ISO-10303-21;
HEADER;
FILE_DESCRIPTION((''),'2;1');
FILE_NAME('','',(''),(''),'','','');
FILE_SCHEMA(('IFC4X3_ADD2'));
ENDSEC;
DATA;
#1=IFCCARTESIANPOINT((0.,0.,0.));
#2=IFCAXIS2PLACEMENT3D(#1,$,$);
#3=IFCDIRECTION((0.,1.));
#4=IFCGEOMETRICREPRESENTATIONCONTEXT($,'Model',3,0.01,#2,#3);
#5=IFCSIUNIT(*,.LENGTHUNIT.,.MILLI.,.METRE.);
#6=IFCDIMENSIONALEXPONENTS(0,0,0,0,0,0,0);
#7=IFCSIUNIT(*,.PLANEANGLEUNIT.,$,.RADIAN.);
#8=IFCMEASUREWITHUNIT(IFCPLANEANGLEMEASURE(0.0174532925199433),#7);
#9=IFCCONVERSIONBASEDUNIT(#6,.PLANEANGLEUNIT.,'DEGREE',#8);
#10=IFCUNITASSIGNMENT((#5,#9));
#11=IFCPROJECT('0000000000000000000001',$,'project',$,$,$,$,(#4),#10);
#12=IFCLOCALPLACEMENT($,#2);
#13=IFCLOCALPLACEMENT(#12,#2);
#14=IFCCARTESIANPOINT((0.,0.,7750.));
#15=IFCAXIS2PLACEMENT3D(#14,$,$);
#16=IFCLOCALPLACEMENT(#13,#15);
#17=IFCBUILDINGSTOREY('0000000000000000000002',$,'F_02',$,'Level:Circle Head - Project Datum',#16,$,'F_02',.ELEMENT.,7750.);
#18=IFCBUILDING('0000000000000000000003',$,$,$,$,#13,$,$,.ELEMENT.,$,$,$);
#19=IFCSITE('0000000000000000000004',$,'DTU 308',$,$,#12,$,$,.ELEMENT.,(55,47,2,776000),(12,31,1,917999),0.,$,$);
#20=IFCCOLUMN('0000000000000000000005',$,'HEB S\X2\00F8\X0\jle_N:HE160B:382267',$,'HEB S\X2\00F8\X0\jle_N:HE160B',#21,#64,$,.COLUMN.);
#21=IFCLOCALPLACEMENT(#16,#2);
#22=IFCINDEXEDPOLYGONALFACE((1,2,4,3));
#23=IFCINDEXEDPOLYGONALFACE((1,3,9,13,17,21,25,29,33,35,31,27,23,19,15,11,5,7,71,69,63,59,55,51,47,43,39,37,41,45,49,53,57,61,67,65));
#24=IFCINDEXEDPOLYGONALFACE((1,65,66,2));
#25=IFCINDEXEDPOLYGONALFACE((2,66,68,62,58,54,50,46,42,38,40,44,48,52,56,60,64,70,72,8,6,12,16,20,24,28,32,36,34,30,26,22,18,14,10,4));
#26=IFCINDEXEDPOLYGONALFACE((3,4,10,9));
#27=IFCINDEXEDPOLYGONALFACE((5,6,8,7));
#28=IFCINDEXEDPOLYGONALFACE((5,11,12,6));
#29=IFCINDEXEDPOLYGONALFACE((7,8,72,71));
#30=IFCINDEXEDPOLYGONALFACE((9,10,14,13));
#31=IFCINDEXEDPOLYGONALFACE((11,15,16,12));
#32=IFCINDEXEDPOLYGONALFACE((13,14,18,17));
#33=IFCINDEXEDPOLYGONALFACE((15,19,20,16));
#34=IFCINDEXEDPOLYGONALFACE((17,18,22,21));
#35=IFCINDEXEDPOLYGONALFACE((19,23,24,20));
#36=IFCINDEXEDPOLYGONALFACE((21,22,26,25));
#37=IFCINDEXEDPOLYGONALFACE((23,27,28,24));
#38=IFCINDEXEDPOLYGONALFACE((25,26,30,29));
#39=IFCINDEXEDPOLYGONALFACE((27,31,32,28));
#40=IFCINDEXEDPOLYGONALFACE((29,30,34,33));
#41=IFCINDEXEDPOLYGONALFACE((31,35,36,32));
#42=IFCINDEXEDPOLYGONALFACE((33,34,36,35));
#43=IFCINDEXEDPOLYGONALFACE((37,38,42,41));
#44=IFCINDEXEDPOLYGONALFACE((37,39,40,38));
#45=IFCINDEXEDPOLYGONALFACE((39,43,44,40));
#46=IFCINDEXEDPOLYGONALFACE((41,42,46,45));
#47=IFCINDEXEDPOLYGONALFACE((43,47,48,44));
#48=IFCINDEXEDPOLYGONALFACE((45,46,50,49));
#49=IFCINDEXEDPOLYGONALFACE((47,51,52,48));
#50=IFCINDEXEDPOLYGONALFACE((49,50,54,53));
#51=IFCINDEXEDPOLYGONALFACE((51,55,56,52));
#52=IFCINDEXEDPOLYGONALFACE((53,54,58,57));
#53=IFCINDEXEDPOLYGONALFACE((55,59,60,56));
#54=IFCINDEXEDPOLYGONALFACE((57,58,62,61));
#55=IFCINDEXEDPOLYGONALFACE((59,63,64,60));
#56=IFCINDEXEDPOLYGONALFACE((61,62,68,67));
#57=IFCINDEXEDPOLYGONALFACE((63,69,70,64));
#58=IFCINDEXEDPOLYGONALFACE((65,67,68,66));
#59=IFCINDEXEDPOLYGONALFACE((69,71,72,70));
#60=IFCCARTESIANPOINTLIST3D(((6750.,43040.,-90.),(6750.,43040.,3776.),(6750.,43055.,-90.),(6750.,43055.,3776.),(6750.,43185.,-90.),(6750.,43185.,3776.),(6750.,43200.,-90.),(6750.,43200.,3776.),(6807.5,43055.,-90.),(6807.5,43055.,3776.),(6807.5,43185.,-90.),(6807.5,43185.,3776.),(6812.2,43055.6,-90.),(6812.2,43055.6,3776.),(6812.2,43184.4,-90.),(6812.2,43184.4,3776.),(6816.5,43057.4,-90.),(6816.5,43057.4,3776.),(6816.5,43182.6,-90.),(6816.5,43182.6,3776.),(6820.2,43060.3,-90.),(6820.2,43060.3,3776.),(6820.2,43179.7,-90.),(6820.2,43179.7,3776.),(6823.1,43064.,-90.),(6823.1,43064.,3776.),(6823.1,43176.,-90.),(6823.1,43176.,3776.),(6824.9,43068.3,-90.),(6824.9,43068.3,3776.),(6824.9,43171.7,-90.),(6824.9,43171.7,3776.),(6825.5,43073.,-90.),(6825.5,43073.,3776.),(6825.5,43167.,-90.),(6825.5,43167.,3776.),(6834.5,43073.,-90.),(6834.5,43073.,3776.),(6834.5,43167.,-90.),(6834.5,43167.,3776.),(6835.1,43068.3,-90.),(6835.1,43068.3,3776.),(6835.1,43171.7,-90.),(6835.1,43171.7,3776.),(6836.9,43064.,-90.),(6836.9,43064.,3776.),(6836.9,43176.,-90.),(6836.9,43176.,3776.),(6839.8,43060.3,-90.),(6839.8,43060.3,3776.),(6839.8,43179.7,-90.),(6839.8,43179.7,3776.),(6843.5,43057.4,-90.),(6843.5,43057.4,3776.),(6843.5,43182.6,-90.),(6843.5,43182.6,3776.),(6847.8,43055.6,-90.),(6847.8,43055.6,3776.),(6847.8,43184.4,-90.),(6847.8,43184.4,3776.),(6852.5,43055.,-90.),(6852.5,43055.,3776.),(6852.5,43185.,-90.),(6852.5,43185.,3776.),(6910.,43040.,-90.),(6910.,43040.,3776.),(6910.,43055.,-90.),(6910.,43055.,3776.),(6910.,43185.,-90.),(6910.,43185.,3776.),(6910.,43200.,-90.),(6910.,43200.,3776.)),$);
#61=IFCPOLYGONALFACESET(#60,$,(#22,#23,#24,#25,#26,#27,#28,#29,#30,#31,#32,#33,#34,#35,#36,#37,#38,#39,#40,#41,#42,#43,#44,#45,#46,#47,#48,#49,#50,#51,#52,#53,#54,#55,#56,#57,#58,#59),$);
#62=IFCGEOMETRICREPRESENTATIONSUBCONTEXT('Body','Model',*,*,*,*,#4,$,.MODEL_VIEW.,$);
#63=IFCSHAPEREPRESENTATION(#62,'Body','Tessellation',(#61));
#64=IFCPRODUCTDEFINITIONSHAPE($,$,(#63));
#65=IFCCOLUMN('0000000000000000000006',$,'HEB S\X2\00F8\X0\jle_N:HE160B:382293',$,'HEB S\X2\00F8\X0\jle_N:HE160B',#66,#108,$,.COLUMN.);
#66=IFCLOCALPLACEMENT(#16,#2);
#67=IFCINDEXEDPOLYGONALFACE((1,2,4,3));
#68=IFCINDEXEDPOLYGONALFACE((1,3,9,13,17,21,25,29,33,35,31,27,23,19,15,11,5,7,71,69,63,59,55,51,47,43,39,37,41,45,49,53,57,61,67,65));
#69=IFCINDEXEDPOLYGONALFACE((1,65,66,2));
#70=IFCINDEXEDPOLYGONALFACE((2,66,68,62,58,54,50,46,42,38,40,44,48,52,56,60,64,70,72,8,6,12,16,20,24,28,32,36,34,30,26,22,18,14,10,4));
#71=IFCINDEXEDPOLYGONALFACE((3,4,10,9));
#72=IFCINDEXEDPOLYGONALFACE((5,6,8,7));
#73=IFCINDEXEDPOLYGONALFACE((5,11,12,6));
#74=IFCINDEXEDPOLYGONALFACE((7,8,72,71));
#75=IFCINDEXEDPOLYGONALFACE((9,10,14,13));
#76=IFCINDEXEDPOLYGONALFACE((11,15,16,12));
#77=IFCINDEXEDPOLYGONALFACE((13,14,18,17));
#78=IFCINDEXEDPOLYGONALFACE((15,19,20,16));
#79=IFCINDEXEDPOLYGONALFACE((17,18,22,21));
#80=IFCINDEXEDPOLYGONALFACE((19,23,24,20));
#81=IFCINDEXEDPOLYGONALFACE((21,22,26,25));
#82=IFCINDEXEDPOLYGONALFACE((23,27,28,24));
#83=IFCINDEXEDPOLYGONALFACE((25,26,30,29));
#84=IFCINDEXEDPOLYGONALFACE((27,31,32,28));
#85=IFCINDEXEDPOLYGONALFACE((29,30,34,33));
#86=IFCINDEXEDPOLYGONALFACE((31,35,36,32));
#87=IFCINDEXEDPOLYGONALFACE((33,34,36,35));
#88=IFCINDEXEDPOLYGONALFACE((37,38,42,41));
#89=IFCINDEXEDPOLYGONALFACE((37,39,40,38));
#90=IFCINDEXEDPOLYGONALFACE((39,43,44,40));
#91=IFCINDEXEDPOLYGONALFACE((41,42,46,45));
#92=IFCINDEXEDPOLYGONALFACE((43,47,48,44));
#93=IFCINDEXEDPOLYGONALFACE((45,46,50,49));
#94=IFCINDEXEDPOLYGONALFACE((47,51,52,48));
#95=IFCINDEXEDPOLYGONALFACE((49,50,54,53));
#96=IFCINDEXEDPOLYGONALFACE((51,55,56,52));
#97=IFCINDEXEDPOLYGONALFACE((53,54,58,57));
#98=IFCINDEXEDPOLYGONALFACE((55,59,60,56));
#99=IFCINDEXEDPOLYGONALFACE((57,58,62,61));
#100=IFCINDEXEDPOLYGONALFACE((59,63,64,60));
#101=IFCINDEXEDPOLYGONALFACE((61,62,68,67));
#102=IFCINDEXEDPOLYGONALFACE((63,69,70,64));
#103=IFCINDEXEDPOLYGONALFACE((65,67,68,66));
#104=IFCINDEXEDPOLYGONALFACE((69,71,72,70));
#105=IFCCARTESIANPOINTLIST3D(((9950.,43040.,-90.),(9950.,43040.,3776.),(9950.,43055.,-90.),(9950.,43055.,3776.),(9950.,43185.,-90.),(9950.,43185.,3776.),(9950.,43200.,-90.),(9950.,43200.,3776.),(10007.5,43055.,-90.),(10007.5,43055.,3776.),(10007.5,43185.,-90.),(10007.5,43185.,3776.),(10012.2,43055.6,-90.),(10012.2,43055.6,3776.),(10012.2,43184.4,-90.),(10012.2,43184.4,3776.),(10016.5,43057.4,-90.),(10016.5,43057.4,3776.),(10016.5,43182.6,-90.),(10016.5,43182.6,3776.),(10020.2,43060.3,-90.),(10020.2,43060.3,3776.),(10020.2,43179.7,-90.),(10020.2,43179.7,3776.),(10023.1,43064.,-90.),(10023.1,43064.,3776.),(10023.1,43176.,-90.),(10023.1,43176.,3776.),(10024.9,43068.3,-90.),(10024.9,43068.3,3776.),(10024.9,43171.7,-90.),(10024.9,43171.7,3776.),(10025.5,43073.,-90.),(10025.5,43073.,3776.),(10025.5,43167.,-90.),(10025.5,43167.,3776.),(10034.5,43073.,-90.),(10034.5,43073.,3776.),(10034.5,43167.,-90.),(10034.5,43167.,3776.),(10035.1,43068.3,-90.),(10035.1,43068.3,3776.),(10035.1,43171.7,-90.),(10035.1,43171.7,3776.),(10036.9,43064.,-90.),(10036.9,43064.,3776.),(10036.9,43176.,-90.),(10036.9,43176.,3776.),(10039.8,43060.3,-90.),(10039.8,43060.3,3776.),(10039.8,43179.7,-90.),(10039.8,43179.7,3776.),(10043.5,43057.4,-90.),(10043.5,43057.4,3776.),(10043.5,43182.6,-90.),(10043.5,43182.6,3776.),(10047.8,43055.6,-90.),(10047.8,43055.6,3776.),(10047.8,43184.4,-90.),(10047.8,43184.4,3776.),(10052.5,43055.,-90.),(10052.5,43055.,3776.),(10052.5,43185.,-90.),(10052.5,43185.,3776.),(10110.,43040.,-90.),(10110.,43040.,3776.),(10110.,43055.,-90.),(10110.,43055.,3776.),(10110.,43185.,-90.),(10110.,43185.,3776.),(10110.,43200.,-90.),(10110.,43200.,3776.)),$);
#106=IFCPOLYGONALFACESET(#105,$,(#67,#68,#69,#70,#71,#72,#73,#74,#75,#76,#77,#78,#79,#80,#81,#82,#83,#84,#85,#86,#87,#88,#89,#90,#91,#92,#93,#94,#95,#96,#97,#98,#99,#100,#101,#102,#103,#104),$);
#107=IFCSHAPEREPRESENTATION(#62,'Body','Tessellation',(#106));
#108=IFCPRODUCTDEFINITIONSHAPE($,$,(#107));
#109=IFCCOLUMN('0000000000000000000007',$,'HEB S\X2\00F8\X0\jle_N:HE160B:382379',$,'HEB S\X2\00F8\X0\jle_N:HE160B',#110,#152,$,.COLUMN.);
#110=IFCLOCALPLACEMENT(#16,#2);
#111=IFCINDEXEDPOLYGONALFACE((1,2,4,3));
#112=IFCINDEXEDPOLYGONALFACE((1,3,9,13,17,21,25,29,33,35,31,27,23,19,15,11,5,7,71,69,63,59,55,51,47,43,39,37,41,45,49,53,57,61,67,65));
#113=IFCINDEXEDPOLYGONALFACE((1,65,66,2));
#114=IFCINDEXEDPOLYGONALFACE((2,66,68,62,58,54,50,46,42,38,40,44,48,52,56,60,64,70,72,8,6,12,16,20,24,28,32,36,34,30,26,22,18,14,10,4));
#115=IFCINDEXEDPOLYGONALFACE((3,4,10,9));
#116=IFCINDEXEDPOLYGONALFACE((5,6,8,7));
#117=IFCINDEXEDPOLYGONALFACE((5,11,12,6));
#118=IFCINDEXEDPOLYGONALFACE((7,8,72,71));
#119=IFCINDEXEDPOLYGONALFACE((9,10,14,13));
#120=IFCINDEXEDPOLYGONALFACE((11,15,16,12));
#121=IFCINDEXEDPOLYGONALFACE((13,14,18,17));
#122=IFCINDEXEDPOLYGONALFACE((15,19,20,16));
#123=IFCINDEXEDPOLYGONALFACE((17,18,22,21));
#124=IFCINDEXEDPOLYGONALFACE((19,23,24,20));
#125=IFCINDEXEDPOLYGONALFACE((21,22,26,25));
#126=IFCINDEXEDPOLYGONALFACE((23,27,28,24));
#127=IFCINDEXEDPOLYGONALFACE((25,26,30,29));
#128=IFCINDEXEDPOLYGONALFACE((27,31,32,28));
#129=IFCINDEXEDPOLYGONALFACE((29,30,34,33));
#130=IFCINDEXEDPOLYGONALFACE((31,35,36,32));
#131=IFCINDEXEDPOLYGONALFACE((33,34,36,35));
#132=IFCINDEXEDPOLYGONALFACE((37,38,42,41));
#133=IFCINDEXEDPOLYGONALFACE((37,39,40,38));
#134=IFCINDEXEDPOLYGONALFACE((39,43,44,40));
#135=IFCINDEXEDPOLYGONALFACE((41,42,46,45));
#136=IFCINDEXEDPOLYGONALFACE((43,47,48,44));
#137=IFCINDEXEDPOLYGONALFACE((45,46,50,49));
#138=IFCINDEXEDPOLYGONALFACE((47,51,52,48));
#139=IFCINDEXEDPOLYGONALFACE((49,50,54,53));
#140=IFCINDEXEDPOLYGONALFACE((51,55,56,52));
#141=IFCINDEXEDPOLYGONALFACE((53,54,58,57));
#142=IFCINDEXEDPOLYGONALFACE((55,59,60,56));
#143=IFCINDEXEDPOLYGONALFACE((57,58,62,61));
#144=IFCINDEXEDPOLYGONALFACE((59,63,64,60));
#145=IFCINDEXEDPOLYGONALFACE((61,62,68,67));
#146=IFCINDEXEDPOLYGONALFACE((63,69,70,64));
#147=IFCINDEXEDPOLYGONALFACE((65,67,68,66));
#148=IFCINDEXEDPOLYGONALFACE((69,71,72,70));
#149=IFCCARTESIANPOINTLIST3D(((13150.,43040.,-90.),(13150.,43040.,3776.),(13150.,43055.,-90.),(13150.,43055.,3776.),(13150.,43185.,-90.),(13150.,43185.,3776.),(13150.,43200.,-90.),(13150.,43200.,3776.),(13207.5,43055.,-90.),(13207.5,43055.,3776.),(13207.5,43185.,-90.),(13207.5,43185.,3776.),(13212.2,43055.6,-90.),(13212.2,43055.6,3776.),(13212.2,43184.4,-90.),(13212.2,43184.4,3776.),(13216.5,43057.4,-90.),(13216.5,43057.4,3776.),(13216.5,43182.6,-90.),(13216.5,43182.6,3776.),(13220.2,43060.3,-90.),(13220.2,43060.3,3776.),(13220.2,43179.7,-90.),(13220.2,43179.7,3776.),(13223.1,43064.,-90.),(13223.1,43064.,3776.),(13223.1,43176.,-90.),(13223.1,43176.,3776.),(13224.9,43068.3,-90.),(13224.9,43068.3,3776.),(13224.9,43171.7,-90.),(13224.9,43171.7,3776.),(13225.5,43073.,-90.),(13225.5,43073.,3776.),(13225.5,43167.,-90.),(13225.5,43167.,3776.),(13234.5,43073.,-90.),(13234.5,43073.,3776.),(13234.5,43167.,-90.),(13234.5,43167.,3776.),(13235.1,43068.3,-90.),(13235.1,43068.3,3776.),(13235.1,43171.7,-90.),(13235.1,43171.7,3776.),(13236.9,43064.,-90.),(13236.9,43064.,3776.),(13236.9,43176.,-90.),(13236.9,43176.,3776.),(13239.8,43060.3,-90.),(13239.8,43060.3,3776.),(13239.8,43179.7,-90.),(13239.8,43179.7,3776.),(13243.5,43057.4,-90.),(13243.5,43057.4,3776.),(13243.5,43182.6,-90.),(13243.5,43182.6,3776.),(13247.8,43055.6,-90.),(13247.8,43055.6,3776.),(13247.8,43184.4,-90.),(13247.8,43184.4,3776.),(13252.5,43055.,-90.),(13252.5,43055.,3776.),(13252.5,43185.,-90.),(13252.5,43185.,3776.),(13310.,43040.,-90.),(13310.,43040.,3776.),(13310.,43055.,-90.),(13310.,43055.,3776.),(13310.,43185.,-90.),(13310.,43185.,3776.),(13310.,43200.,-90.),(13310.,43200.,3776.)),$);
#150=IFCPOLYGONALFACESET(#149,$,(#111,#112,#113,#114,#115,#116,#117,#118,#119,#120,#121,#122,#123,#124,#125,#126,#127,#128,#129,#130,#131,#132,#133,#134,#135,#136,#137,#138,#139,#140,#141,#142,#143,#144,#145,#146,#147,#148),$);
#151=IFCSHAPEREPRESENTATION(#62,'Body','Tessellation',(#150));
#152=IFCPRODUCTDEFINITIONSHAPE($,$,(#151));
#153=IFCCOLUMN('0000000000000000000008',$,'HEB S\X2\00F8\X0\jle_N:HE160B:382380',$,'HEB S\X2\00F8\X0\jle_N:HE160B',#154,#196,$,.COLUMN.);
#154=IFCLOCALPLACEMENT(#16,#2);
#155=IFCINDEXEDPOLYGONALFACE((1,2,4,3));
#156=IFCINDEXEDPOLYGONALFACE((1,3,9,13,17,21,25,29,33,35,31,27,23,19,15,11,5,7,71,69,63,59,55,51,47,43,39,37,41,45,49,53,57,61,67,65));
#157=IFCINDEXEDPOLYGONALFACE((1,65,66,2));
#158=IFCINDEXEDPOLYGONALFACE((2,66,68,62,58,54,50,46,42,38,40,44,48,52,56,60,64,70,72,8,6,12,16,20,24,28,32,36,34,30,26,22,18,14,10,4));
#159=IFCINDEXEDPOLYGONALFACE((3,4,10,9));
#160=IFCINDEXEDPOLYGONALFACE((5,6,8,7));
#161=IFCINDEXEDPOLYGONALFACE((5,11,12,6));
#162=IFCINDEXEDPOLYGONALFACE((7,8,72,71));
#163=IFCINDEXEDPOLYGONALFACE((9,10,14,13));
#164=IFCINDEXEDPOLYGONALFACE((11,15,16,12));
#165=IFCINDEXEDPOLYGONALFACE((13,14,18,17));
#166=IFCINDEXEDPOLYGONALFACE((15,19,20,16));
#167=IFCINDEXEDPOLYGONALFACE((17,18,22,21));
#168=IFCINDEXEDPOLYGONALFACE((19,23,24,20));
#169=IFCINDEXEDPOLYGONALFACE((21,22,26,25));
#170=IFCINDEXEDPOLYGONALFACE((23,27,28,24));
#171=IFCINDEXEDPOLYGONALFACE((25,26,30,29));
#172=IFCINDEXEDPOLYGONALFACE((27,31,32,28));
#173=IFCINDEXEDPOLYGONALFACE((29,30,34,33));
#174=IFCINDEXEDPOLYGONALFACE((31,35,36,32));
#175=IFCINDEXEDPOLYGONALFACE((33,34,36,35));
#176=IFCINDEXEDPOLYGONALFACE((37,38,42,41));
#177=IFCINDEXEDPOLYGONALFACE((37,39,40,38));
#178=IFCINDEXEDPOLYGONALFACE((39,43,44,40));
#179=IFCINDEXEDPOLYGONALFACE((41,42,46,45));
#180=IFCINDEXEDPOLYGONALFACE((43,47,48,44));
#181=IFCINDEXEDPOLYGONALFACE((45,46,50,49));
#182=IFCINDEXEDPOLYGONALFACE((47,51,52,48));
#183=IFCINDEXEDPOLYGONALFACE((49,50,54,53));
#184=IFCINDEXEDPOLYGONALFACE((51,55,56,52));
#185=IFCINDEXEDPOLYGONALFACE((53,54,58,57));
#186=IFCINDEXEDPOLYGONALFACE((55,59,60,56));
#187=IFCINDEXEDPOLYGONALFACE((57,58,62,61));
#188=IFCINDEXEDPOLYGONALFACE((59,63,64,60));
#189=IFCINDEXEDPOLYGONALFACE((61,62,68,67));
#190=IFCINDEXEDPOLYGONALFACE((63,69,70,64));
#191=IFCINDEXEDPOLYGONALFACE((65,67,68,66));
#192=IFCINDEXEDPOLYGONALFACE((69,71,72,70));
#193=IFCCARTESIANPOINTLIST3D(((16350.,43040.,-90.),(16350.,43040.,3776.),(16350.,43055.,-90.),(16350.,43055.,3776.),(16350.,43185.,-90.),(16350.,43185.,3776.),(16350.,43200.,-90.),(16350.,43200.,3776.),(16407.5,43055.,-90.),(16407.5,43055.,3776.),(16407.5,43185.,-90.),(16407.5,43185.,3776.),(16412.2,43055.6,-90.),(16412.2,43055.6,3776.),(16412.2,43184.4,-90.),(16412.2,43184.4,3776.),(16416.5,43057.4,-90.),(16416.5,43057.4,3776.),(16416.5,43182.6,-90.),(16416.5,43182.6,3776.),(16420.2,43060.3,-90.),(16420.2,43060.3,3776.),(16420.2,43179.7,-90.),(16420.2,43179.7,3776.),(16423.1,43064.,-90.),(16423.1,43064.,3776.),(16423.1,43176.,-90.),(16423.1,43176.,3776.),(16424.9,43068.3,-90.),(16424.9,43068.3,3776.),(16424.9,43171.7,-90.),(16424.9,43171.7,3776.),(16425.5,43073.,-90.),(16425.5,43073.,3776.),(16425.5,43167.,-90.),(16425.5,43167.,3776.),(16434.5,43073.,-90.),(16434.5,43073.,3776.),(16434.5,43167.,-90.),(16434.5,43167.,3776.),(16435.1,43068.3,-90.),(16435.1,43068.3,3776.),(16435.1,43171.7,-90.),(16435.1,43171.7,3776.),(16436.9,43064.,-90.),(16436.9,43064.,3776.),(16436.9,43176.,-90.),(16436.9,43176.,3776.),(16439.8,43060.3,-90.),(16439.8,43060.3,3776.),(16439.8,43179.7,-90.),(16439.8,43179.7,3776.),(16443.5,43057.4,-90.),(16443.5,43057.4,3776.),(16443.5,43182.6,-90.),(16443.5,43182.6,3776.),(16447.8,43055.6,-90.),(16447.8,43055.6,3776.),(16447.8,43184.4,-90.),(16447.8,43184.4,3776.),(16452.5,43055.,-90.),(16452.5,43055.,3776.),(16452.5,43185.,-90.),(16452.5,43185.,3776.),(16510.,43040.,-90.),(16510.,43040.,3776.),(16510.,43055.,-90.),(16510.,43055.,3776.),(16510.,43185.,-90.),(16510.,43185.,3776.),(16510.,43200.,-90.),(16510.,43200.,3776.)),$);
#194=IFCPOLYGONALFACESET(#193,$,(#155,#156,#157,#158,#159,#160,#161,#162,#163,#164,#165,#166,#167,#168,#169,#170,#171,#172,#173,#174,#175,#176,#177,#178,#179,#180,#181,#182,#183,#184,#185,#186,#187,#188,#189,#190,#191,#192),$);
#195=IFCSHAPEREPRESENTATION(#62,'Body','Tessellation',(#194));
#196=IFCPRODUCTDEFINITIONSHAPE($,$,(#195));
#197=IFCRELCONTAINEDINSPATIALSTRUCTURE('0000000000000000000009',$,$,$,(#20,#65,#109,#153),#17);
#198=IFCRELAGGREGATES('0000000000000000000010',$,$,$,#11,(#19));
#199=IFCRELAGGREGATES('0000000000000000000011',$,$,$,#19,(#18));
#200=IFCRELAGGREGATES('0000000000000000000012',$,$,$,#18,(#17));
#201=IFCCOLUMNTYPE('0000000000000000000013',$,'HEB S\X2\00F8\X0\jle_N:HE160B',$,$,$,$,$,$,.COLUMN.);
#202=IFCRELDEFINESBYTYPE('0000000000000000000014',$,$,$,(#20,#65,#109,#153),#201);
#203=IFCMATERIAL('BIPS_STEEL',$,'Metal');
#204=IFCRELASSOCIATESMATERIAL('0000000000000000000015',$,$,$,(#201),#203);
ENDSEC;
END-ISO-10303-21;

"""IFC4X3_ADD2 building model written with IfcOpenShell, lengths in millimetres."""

from ifc_helpers import new_model, entity, si_unit, converted_unit, direction, frame, frame_2d, origin, place, context, subcontext, project, spatial, i_section, extrude, source, transform, mapped, material, material_profile, profile_set, type_object, element, save


model = new_model("IFC4X3_ADD2")

# Units and contexts
model_context = context("Model", 3, precision=0.01, world=origin(), true_north=direction((0.0, 1.0)))
body_context = subcontext(model_context, "Body", "Model", "MODEL_VIEW")
ifc_project = project(units=[si_unit("LENGTHUNIT", "METRE", prefix="MILLI"), converted_unit("PLANEANGLEUNIT", "DEGREE", entity("IfcPlaneAngleMeasure", 0.0174532925199433), si_unit("PLANEANGLEUNIT", "RADIAN"), dimensions=[0, 0, 0, 0, 0, 0, 0])], contexts=[model_context])

# Site, building, storey
site_placement = place(None, origin())
site = spatial("IfcSite", under=ifc_project, at=site_placement, Name="DTU 308", CompositionType="ELEMENT", RefLatitude=(55, 47, 2, 776000), RefLongitude=(12, 31, 1, 917999), RefElevation=0.0)
building_placement = place(site_placement, origin())
building = spatial("IfcBuilding", under=site, at=building_placement, CompositionType="ELEMENT")
storey_placement = place(building_placement, frame((0.0, 0.0, 7750.0)))
storey = spatial("IfcBuildingStorey", under=building, at=storey_placement, Name="F_02", ObjectType="Level:Circle Head - Project Datum", LongName="F_02", CompositionType="ELEMENT", Elevation=7750.0)

# Columns
ifc_material = material(Name="BIPS_STEEL", Category="Metal")
ifc_material_profile_1 = material_profile(ifc_material, i_section(OverallWidth=160.0, OverallDepth=160.0, WebThickness=9.0, FlangeThickness=15.0, FilletRadius=18.0, at=frame_2d((0.0, 0.0), x_axis=(1.0, 0.0))), Name="HE160B")
ifc_profile_set_1 = profile_set([ifc_material_profile_1], Name="HE160B")
column_type_1 = type_object("IfcColumnType", Name="HEB Søjle_N:HE160B", PredefinedType="COLUMN", material=ifc_profile_set_1)
shared_shape_1 = source(origin(), body_context, "Body", "SweptSolid", [
    extrude(i_section(OverallWidth=160.0, OverallDepth=160.0, WebThickness=9.0, FlangeThickness=15.0, FilletRadius=18.0, at=frame_2d((0.0, 0.0), x_axis=(1.0, 0.0))), frame((0.0, 0.0, 7660.0), z_axis=(0.0, 0.0, 1.0), x_axis=(-1.0, 0.0, 0.0)), (0.0, 0.0, 1.0), 3866.0),
])
for number, where, name in (
    (1, (6830.0, 43120.0, -7750.0), "HEB Søjle_N:HE160B:382267"),
    (2, (10030.0, 43120.0, -7750.0), "HEB Søjle_N:HE160B:382293"),
    (3, (13230.0, 43120.0, -7750.0), "HEB Søjle_N:HE160B:382379"),
    (4, (16430.0, 43120.0, -7750.0), "HEB Søjle_N:HE160B:382380"),
):
    element("IfcColumn", number, at=place(storey_placement, frame(where)), inside=storey, type_object=column_type_1, Name=name, ObjectType="HEB Søjle_N:HE160B", PredefinedType="COLUMN", context=body_context, shape_type="MappedRepresentation", body=[
        mapped(shared_shape_1, transform((0.0, 0.0, 0.0), scale=1.0)),
    ])

save(model, "model.ifc")
